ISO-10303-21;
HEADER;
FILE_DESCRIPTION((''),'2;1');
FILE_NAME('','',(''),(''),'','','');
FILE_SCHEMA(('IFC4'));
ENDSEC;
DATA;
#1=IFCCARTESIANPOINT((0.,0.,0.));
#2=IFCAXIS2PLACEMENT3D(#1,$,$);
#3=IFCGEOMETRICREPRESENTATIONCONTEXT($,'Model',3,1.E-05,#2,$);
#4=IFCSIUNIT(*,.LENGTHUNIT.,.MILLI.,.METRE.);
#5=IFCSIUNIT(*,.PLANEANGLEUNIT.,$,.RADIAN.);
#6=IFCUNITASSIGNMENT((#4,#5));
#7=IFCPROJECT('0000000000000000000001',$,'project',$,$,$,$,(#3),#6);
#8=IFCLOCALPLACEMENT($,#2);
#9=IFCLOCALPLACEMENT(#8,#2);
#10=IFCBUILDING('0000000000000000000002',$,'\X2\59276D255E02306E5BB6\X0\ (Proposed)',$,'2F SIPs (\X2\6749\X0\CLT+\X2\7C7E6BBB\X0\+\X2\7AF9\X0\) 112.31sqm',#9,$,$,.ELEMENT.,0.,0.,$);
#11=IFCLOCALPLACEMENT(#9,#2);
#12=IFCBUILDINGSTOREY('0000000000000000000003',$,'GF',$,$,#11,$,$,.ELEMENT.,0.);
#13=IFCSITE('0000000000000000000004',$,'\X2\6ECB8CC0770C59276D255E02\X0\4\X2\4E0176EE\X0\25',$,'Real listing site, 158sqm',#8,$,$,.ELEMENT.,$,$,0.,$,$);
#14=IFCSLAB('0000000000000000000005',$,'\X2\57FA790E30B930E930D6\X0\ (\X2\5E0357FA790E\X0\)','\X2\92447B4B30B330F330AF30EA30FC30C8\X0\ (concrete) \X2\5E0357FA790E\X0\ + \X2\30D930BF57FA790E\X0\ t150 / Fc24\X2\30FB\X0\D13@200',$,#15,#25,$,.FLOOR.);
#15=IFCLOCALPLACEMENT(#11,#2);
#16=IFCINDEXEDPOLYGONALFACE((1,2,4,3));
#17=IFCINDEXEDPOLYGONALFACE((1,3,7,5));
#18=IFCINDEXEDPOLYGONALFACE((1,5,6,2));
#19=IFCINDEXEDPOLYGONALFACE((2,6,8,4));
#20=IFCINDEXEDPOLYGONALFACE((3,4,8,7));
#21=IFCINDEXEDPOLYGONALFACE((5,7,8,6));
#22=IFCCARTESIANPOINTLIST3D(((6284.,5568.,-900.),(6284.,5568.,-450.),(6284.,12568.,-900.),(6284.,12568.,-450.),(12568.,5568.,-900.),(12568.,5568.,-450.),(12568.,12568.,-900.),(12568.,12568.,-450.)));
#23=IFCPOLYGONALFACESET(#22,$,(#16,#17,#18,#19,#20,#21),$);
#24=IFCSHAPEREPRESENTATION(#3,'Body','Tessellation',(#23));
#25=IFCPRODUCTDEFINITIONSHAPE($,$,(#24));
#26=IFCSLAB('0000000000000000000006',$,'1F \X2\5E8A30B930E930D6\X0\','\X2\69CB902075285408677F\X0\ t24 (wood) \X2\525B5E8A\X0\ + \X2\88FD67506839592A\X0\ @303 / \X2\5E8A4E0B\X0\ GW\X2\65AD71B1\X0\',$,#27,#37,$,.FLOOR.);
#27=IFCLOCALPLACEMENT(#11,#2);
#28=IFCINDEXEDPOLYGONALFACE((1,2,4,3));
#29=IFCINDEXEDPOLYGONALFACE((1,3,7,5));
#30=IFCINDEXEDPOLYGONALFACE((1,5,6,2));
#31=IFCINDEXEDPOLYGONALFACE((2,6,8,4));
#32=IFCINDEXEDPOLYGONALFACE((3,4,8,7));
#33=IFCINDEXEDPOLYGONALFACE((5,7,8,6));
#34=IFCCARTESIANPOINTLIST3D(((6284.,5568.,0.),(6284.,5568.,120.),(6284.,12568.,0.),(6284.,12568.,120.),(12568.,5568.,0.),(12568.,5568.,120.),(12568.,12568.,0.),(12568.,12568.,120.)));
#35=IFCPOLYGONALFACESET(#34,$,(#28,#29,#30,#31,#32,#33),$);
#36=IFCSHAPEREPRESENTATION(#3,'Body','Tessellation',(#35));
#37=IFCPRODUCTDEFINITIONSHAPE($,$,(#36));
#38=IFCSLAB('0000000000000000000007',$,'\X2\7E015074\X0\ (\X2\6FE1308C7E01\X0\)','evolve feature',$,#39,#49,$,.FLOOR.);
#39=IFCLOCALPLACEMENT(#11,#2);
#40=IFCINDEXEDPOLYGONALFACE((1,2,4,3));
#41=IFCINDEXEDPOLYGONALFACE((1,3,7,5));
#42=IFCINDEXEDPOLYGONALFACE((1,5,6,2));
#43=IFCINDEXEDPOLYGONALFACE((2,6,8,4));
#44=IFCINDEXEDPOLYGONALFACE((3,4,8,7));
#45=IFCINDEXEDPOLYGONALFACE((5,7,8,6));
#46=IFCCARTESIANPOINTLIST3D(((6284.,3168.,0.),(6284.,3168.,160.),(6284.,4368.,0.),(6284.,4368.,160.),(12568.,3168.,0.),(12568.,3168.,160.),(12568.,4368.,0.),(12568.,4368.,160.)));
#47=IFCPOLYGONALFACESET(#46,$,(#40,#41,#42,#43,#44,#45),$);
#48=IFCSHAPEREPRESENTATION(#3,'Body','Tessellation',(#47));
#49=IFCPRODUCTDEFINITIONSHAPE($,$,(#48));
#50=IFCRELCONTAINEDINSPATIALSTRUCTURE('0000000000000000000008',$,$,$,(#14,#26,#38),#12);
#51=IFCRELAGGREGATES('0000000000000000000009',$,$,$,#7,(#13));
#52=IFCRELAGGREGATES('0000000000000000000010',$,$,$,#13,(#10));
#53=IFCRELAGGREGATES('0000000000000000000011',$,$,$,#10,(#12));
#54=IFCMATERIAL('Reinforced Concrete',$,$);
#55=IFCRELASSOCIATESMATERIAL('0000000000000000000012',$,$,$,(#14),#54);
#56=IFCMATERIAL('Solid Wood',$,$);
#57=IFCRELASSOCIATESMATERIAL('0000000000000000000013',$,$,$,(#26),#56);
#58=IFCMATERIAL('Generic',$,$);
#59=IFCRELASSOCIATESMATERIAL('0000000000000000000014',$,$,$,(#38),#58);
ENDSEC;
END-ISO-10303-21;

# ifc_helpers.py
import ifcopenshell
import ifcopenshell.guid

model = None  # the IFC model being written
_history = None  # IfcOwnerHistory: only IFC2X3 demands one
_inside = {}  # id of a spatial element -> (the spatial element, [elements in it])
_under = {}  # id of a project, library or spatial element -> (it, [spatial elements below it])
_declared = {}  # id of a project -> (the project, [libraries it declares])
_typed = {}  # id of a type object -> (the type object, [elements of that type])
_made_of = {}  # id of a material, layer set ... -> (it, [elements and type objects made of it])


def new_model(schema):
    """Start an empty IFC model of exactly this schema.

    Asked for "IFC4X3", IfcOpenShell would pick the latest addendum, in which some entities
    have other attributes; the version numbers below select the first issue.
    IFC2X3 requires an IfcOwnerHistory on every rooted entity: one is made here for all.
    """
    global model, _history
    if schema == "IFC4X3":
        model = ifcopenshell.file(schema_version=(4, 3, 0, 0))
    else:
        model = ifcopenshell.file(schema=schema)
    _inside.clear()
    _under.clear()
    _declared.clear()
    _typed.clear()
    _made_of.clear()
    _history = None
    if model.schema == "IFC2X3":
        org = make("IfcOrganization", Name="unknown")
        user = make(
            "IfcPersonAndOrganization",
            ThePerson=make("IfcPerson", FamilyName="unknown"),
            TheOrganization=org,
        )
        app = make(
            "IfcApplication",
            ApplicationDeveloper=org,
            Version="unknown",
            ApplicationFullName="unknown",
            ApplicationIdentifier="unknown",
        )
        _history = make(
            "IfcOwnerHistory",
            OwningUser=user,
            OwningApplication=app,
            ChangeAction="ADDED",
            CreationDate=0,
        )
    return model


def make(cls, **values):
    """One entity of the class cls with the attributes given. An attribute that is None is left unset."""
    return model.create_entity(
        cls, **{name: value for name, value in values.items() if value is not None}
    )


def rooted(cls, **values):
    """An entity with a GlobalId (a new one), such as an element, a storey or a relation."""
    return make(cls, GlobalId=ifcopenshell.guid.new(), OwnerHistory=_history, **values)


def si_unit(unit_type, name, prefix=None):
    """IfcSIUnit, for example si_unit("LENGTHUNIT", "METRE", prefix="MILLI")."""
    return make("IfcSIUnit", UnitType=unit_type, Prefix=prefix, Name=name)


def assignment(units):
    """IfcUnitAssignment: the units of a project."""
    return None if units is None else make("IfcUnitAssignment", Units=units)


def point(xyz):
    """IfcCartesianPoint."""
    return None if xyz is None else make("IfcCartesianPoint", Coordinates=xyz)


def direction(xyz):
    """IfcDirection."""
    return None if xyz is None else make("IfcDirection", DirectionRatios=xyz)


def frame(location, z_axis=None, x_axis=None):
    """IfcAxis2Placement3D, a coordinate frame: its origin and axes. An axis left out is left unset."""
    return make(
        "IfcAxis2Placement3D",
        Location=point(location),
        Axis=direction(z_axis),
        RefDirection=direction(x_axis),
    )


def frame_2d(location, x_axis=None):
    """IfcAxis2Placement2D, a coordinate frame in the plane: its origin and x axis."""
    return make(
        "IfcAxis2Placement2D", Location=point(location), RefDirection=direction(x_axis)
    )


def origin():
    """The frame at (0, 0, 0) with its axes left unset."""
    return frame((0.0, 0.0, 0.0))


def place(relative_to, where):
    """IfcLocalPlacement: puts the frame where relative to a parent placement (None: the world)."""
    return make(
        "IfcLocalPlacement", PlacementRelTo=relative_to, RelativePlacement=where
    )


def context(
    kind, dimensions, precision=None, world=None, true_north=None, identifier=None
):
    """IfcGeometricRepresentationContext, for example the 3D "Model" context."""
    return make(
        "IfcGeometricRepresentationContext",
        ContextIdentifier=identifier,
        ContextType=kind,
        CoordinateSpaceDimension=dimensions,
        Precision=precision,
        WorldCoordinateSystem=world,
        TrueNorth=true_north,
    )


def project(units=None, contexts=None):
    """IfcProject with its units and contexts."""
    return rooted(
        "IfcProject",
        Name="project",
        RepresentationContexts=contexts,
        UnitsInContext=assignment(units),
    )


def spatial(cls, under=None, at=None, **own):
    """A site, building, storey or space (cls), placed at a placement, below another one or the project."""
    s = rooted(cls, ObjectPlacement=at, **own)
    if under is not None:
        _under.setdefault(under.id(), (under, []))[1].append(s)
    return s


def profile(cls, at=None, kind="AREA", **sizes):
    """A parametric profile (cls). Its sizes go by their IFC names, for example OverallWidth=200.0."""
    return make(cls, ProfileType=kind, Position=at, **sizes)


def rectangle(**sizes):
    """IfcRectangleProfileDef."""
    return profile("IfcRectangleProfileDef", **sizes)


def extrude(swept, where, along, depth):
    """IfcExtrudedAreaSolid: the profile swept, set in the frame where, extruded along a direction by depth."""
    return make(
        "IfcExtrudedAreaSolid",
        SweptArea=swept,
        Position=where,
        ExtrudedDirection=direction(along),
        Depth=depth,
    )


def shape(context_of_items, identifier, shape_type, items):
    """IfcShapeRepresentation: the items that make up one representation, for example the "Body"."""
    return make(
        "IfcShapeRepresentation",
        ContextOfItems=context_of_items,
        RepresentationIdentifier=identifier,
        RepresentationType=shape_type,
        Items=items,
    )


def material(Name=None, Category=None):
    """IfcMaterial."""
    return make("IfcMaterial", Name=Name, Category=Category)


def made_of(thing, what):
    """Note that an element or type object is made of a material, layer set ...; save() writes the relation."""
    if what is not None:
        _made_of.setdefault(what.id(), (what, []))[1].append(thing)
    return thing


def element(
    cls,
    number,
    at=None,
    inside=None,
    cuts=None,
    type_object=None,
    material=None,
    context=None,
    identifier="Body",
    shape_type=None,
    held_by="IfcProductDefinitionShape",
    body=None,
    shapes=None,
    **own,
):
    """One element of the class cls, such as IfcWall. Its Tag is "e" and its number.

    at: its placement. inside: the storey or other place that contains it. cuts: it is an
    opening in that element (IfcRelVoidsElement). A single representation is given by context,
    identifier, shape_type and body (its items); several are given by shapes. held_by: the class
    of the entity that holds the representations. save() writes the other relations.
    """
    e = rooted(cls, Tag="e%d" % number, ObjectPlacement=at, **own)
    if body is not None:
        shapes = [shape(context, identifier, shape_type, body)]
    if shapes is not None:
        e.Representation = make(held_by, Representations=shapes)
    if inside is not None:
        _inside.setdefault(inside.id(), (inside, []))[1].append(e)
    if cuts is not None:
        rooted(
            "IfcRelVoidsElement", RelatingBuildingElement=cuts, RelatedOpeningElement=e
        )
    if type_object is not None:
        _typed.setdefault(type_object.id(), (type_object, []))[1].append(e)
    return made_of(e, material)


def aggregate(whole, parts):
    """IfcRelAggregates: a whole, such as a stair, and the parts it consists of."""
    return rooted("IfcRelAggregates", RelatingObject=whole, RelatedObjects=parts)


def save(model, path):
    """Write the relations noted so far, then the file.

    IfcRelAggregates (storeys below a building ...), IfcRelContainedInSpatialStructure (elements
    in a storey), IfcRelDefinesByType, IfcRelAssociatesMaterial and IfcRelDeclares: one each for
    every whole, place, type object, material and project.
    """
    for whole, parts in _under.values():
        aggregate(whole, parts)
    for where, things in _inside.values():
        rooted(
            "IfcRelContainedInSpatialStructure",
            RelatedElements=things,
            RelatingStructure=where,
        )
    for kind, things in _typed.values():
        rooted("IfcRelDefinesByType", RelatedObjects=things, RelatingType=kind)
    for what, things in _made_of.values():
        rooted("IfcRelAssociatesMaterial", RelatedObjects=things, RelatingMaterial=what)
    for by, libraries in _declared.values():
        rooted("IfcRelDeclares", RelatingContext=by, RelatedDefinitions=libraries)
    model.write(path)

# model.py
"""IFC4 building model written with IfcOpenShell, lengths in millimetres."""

from ifc_helpers import new_model, si_unit, frame, frame_2d, origin, place, context, project, spatial, rectangle, extrude, material, element, save


model = new_model("IFC4")

# Units and contexts
model_context = context("Model", 3, precision=1e-05, world=origin())
ifc_project = project(units=[si_unit("LENGTHUNIT", "METRE", prefix="MILLI"), si_unit("PLANEANGLEUNIT", "RADIAN")], contexts=[model_context])

# Site, building, storey
site_placement = place(None, origin())
site = spatial("IfcSite", under=ifc_project, at=site_placement, Name="滋賀県大津市4丁目25", ObjectType="Real listing site, 158sqm", CompositionType="ELEMENT", RefElevation=0.0)
building_placement = place(site_placement, origin())
building = spatial("IfcBuilding", under=site, at=building_placement, Name="大津市の家 (Proposed)", ObjectType="2F SIPs (杉CLT+籾殻+竹) 112.31sqm", CompositionType="ELEMENT", ElevationOfRefHeight=0.0, ElevationOfTerrain=0.0)
storey_placement = place(building_placement, origin())
storey = spatial("IfcBuildingStorey", under=building, at=storey_placement, Name="GF", CompositionType="ELEMENT", Elevation=0.0)

# Slabs
ifc_material_1 = material(Name="Reinforced Concrete")
slab_1_placement = place(storey_placement, frame((3142.0, 2784.0, -450.0)))
element("IfcSlab", 1, at=slab_1_placement, inside=storey, material=ifc_material_1, Name="基礎スラブ (布基礎)", Description="鉄筋コンクリート (concrete) 布基礎 + ベタ基礎 t150 / Fc24・D13@200", PredefinedType="FLOOR", context=model_context, shape_type="SweptSolid", body=[
    extrude(rectangle(XDim=6284.0, YDim=7000.0, at=frame_2d((3142.0, 3500.0))), frame((3142.0, 2784.0, -450.0)), (0.0, 0.0, 1.0), 450.0),
])
ifc_material_2 = material(Name="Solid Wood")
slab_2_placement = place(storey_placement, frame((3142.0, 2784.0, 0.0)))
element("IfcSlab", 2, at=slab_2_placement, inside=storey, material=ifc_material_2, Name="1F 床スラブ", Description="構造用合板 t24 (wood) 剛床 + 製材根太 @303 / 床下 GW断熱", PredefinedType="FLOOR", context=model_context, shape_type="SweptSolid", body=[
    extrude(rectangle(XDim=6284.0, YDim=7000.0, at=frame_2d((3142.0, 3500.0))), frame((3142.0, 2784.0, 0.0)), (0.0, 0.0, 1.0), 120.0),
])
ifc_material_3 = material(Name="Generic")
slab_3_placement = place(storey_placement, frame((3142.0, 1584.0, 0.0)))
element("IfcSlab", 3, at=slab_3_placement, inside=storey, material=ifc_material_3, Name="縁側 (濡れ縁)", Description="evolve feature", PredefinedType="FLOOR", context=model_context, shape_type="SweptSolid", body=[
    extrude(rectangle(XDim=6284.0, YDim=1200.0, at=frame_2d((3142.0, 600.0))), frame((3142.0, 1584.0, 0.0)), (0.0, 0.0, 1.0), 160.0),
])

save(model, "model.ifc")
